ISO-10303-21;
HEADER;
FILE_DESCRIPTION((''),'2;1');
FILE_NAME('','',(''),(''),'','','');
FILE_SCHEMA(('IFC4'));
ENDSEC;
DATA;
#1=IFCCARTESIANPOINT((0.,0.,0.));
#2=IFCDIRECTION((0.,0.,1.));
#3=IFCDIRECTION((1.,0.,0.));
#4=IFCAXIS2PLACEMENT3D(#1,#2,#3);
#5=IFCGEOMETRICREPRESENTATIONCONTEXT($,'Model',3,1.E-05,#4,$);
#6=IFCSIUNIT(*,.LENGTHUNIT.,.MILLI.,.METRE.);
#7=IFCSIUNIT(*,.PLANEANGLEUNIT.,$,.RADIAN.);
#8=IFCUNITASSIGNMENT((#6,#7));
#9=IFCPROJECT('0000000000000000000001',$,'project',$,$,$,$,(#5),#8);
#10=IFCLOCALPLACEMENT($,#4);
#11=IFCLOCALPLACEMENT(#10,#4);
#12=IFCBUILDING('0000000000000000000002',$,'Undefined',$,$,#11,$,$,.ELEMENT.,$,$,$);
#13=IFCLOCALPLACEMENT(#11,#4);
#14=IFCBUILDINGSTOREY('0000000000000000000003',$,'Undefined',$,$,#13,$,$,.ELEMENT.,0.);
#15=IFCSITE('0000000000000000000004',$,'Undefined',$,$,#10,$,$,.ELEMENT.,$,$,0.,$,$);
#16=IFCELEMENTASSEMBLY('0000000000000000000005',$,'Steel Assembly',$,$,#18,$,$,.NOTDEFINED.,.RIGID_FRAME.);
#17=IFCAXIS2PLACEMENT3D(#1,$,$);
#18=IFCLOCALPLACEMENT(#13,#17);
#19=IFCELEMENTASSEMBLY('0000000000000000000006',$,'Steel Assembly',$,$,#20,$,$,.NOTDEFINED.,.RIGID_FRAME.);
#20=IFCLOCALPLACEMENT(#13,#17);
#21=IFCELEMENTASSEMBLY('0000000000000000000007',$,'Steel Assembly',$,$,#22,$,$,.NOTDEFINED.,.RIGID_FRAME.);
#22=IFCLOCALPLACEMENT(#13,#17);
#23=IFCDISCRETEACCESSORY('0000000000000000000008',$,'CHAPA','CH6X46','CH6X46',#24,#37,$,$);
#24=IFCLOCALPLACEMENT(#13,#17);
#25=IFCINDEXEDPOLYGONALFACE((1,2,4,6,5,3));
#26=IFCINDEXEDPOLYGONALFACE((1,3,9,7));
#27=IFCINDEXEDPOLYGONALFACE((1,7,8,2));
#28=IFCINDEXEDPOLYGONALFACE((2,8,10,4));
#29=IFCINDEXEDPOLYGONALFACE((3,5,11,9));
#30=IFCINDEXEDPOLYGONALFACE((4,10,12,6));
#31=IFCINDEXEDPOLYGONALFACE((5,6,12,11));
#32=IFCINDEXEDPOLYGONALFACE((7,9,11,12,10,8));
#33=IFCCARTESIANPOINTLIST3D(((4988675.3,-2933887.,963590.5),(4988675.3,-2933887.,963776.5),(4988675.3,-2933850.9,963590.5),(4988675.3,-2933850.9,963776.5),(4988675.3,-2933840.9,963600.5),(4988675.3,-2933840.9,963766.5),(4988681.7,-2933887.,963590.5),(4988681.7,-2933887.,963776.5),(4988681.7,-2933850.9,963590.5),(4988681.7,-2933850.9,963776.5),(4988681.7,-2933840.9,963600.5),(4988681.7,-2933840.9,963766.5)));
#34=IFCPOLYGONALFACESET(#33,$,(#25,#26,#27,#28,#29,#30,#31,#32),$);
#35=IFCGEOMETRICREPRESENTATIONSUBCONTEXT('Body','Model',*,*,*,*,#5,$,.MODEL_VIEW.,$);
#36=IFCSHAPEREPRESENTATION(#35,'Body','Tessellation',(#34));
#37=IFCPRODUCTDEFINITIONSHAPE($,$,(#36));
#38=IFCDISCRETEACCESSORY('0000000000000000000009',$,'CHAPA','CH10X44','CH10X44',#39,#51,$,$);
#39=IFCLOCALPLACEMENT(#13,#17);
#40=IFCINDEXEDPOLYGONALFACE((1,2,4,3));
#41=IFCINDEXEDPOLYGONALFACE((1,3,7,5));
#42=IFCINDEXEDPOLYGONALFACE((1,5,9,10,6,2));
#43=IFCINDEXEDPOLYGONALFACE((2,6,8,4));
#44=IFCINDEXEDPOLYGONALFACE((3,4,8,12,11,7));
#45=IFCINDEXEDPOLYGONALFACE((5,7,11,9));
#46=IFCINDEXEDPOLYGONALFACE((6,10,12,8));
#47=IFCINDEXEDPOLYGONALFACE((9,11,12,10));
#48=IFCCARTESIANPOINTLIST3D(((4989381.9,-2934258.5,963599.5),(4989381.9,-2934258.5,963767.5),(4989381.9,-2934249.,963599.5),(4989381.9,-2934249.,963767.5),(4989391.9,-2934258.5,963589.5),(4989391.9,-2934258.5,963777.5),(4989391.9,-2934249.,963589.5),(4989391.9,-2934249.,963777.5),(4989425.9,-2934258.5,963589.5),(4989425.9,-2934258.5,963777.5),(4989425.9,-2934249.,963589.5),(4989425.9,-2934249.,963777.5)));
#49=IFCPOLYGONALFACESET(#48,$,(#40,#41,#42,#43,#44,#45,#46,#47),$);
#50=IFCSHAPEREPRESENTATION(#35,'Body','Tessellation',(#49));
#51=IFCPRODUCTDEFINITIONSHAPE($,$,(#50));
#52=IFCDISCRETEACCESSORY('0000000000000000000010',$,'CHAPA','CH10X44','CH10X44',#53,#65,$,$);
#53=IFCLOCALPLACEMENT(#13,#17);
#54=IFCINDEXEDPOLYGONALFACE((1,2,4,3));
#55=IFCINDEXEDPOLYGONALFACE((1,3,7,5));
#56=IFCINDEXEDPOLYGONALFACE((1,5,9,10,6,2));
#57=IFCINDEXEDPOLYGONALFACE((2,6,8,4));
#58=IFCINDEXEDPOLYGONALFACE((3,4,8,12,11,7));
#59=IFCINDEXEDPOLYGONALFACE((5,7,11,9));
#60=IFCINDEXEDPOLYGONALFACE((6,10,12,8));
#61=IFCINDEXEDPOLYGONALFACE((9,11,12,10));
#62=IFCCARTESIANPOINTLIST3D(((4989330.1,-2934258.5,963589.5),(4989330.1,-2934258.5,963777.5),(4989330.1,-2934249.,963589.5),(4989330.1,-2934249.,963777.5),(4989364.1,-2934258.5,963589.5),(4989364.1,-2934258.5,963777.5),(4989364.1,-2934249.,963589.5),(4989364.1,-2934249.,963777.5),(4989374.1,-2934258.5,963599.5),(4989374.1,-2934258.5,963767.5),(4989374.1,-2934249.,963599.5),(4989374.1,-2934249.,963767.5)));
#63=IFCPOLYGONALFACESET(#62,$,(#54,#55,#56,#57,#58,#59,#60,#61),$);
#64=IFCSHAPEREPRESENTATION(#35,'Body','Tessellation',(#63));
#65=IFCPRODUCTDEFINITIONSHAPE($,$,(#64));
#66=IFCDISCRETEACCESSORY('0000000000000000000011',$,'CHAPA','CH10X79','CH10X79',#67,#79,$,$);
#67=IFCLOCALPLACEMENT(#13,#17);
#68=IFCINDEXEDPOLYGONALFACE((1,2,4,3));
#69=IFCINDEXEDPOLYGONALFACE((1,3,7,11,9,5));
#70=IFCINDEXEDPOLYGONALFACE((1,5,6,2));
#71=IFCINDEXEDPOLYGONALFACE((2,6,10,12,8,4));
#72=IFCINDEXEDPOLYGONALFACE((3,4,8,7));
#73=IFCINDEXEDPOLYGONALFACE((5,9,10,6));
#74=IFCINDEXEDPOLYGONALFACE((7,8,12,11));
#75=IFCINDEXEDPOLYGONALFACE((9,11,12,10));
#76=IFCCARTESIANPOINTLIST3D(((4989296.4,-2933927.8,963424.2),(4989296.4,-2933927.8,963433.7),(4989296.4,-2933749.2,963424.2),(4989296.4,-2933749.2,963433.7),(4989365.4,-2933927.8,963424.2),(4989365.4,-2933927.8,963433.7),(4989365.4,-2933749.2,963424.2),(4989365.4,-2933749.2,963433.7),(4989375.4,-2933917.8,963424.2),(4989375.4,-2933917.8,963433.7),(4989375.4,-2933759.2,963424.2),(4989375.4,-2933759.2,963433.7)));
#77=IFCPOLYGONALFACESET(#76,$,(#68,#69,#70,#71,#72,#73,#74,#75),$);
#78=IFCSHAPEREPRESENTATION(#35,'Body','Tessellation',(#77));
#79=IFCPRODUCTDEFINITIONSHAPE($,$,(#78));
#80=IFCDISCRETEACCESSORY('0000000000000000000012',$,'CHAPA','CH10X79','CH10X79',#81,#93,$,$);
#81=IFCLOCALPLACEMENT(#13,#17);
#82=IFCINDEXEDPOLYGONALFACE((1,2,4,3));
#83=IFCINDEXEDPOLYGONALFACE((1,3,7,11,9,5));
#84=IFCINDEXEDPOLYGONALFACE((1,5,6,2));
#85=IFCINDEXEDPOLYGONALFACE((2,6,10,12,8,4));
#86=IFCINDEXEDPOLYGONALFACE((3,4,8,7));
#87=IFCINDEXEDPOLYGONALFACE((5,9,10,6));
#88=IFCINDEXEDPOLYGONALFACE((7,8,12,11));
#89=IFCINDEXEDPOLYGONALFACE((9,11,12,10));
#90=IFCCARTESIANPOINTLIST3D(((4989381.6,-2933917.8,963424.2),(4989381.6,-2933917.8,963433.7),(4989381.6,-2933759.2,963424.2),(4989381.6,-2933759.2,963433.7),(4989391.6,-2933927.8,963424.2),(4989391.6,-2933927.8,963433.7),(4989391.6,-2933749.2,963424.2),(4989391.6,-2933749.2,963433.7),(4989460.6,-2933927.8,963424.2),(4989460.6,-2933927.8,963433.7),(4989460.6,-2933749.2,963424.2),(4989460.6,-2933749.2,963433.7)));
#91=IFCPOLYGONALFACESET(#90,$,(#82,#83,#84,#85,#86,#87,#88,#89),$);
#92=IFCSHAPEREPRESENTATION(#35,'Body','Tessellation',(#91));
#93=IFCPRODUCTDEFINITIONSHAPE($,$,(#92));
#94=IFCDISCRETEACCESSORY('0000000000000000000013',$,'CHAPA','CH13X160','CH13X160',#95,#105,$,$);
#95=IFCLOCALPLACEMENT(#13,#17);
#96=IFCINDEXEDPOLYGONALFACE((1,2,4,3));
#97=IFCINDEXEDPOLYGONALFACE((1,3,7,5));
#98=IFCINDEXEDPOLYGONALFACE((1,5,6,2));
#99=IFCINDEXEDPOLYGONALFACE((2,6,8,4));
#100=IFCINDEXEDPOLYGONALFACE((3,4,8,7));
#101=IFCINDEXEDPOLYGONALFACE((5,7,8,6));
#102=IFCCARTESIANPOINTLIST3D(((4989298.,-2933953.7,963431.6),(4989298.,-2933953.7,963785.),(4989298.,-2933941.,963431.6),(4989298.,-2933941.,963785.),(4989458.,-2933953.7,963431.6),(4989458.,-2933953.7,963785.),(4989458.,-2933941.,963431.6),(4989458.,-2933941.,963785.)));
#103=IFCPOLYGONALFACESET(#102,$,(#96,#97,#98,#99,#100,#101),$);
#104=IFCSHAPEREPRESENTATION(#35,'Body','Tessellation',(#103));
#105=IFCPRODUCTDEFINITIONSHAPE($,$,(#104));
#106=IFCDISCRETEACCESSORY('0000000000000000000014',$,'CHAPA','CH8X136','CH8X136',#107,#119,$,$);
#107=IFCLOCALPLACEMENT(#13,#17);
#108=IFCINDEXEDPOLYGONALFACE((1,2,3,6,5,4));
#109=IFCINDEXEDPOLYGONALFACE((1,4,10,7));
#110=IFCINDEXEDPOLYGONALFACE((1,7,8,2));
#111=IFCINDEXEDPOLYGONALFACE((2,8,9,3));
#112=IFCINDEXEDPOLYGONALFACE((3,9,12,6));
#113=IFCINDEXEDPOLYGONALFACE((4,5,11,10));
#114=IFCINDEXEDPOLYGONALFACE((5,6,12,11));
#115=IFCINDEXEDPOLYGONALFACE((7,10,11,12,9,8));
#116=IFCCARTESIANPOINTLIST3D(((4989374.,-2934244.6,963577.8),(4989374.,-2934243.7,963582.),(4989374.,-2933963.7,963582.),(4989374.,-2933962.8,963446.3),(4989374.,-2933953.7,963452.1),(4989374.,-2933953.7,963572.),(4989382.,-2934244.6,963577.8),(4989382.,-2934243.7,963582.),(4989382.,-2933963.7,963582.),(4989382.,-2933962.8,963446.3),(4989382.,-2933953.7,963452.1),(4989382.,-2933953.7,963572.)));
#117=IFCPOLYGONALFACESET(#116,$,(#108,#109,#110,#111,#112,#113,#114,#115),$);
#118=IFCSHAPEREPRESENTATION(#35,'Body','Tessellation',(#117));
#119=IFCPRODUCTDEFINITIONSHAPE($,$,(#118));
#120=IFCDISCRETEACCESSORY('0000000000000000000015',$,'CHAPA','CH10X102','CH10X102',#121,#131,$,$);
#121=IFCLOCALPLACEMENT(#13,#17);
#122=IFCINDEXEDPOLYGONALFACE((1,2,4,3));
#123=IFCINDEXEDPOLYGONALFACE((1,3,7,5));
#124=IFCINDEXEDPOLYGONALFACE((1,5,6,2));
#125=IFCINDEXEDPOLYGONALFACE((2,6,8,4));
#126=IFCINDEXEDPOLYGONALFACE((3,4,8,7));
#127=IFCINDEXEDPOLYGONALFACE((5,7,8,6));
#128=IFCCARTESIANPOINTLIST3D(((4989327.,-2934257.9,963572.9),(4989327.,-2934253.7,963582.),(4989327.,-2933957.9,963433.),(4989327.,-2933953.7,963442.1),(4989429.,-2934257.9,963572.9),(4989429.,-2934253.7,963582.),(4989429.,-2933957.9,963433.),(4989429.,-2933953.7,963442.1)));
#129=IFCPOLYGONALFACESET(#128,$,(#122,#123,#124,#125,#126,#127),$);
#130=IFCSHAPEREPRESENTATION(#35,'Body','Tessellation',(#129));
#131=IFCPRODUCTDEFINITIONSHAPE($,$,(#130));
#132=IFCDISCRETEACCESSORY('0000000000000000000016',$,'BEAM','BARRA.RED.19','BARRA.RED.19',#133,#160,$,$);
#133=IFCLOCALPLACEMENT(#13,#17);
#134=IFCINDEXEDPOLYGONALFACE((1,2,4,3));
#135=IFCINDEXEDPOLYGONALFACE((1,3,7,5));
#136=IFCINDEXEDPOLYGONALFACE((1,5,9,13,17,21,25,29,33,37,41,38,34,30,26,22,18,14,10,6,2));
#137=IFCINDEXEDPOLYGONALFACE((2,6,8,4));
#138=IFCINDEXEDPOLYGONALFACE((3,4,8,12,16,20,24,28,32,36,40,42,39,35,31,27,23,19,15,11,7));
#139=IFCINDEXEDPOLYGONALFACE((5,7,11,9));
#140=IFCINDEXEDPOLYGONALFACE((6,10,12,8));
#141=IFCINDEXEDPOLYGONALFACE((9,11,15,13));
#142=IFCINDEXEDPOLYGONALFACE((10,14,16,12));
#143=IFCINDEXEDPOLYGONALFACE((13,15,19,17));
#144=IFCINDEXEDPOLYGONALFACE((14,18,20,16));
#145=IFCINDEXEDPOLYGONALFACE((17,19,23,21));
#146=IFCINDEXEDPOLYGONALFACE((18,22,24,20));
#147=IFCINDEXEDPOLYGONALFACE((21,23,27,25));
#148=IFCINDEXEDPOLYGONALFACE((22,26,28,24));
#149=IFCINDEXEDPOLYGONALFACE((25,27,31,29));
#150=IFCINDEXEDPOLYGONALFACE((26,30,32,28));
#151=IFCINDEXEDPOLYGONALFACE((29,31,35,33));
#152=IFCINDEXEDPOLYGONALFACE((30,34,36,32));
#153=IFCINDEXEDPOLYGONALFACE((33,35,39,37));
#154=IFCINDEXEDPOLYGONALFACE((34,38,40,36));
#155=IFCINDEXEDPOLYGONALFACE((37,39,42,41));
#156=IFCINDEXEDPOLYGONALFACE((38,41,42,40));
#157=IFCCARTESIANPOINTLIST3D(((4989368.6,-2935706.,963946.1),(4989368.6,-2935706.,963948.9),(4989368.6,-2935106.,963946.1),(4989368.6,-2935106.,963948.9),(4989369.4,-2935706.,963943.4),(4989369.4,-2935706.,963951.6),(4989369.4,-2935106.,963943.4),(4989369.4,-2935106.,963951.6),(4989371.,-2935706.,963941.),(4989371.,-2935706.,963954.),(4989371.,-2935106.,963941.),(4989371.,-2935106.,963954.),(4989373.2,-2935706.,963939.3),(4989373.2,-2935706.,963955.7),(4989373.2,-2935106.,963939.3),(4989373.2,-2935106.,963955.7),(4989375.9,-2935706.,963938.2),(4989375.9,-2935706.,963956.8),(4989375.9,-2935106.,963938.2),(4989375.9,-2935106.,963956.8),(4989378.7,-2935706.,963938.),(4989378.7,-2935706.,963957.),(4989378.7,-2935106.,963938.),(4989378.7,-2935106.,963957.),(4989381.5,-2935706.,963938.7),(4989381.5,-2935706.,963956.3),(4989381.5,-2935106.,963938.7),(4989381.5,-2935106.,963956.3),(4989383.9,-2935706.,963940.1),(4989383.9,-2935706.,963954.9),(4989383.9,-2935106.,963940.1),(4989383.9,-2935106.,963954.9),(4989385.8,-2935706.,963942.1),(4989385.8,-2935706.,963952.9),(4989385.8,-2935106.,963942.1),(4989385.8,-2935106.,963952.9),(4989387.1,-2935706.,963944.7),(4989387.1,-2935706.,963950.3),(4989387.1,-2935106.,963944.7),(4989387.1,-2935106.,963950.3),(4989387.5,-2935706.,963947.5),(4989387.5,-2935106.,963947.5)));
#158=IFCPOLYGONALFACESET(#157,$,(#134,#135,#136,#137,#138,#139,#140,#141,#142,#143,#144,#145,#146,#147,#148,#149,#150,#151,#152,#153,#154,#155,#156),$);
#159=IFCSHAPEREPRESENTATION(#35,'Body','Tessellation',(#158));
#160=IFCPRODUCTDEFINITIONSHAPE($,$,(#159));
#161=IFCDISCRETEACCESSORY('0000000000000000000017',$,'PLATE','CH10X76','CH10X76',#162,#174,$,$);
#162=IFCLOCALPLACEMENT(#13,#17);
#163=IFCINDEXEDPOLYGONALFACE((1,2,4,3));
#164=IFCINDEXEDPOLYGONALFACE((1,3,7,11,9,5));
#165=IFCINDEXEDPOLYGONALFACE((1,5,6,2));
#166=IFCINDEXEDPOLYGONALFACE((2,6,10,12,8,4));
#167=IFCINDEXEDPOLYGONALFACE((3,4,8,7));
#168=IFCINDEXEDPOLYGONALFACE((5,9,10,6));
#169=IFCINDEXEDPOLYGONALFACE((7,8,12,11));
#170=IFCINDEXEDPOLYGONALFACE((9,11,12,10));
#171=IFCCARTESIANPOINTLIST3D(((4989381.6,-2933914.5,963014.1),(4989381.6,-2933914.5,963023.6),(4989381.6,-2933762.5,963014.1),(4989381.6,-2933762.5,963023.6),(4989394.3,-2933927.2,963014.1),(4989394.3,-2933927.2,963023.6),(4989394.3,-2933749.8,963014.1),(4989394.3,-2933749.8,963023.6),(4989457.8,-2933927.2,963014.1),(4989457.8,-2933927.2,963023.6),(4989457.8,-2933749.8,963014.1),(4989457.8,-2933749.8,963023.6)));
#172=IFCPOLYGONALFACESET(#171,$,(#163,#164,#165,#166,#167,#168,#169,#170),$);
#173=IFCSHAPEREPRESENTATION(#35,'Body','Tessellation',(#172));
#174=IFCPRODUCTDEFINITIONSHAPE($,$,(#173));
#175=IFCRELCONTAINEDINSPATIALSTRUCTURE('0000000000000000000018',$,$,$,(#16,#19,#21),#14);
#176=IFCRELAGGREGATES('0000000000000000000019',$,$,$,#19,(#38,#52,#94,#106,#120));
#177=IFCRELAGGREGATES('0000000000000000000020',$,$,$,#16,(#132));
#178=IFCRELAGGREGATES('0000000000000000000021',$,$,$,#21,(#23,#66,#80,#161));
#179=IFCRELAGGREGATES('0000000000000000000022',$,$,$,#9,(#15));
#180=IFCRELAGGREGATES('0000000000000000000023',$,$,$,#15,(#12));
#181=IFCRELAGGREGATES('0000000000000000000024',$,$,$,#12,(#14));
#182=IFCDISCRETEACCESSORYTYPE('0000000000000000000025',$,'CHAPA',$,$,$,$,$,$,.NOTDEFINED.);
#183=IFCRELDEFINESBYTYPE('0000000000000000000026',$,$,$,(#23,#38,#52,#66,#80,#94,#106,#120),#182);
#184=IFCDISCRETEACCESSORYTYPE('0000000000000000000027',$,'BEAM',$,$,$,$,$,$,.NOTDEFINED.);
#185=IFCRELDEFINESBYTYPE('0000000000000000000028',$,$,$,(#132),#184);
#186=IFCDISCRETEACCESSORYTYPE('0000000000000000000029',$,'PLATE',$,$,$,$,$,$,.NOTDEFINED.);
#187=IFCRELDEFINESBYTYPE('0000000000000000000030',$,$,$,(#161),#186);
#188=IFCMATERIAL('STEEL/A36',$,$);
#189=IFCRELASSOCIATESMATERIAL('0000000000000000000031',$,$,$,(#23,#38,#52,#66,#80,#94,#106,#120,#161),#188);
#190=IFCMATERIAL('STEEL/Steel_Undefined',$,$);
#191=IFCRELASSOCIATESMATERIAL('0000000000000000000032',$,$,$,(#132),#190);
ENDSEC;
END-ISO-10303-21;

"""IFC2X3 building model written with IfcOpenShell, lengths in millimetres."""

from ifc_helpers import new_model, si_unit, frame, origin_with_axes, origin_2d_with_axis, place, context, subcontext, project, spatial, polyline, rectangle, circle, outline, extrude, boolean, material, type_object, element, aggregate, save


model = new_model("IFC2X3")

# Units and contexts
model_context = context("Model", 3, precision=1e-05, world=origin_with_axes())
body_context = subcontext(model_context, "Body", "Model", "MODEL_VIEW")
ifc_project = project(units=[si_unit("LENGTHUNIT", "METRE", prefix="MILLI"), si_unit("PLANEANGLEUNIT", "RADIAN")], contexts=[model_context])

# Site, building, storey
site_placement = place(None, origin_with_axes())
site = spatial("IfcSite", under=ifc_project, at=site_placement, Name="Undefined", CompositionType="ELEMENT", RefElevation=0.0)
building_placement = place(site_placement, origin_with_axes())
building = spatial("IfcBuilding", under=site, at=building_placement, Name="Undefined", CompositionType="ELEMENT")
storey_placement = place(building_placement, origin_with_axes())
storey = spatial("IfcBuildingStorey", under=building, at=storey_placement, Name="Undefined", CompositionType="ELEMENT", Elevation=0.0)

# Element assembly
assembly_1_placement = place(storey_placement, origin_with_axes())
assembly_1 = element("IfcElementAssembly", 1, at=assembly_1_placement, inside=storey, Name="Steel Assembly", AssemblyPlace="NOTDEFINED", PredefinedType="RIGID_FRAME")
ifc_material_1 = material(Name="STEEL/Steel_Undefined")

# Element assembly
assembly_2_placement = place(storey_placement, origin_with_axes())
assembly_2 = element("IfcElementAssembly", 2, at=assembly_2_placement, inside=storey, Name="Steel Assembly", AssemblyPlace="NOTDEFINED", PredefinedType="RIGID_FRAME")
ifc_material_2 = material(Name="STEEL/A36")
discrete_accessory_type_1 = type_object("IfcDiscreteAccessoryType", Name="CHAPA")

# Element assembly, discrete accessory
assembly_3_placement = place(storey_placement, origin_with_axes())
assembly_3 = element("IfcElementAssembly", 3, at=assembly_3_placement, inside=storey, Name="Steel Assembly", AssemblyPlace="NOTDEFINED", PredefinedType="RIGID_FRAME")
discrete_accessory_1_placement = place(assembly_3_placement, frame((4988678.5, -2933840.9, 963776.5), z_axis=(1.0, 0.0, 0.0), x_axis=(0.0, -1.0, 0.0)))
discrete_accessory_1 = element("IfcDiscreteAccessory", 4, at=discrete_accessory_1_placement, type_object=discrete_accessory_type_1, material=ifc_material_2, Name="CHAPA", Description="CH6X46", ObjectType="CH6X46", context=body_context, shape_type="SweptSolid", body=[
    extrude(outline(polyline([(0.0, 10.0), (10.0, 0.0), (46.1, 0.0), (46.1, 186.0), (10.0, 186.0), (0.0, 176.0), (0.0, 10.0)])), frame((0.0, 0.0, -3.2), z_axis=(0.0, 0.0, 1.0), x_axis=(1.0, 0.0, 0.0)), (0.0, 0.0, 1.0), 6.4),
])

# Discrete accessories
discrete_accessory_2_placement = place(assembly_2_placement, frame((4989381.9, -2934253.7, 963589.5), z_axis=(0.0, -1.0, 0.0), x_axis=(1.0, 0.0, 0.0)))
discrete_accessory_2 = element("IfcDiscreteAccessory", 5, at=discrete_accessory_2_placement, type_object=discrete_accessory_type_1, material=ifc_material_2, Name="CHAPA", Description="CH10X44", ObjectType="CH10X44", context=body_context, shape_type="SweptSolid", body=[
    extrude(outline(polyline([(0.0, 10.0), (10.0, 0.0), (44.0, 0.0), (44.0, 188.0), (10.0, 188.0), (0.0, 178.0), (0.0, 10.0)])), frame((0.0, 0.0, -4.8), z_axis=(0.0, 0.0, 1.0), x_axis=(1.0, 0.0, 0.0)), (0.0, 0.0, 1.0), 9.5),
])
discrete_accessory_3_placement = place(assembly_2_placement, frame((4989374.1, -2934253.7, 963589.5), z_axis=(0.0, 1.0, 0.0), x_axis=(-1.0, 0.0, 0.0)))
discrete_accessory_3 = element("IfcDiscreteAccessory", 6, at=discrete_accessory_3_placement, type_object=discrete_accessory_type_1, material=ifc_material_2, Name="CHAPA", Description="CH10X44", ObjectType="CH10X44", context=body_context, shape_type="SweptSolid", body=[
    extrude(outline(polyline([(0.0, 10.0), (10.0, 0.0), (44.0, 0.0), (44.0, 188.0), (10.0, 188.0), (0.0, 178.0), (0.0, 10.0)])), frame((0.0, 0.0, -4.8), z_axis=(0.0, 0.0, 1.0), x_axis=(1.0, 0.0, 0.0)), (0.0, 0.0, 1.0), 9.5),
])
discrete_accessory_4_placement = place(assembly_3_placement, frame((4989296.4, -2933927.8, 963429.0), z_axis=(0.0, 0.0, 1.0), x_axis=(1.0, 0.0, 0.0)))
discrete_accessory_4 = element("IfcDiscreteAccessory", 7, at=discrete_accessory_4_placement, type_object=discrete_accessory_type_1, material=ifc_material_2, Name="CHAPA", Description="CH10X79", ObjectType="CH10X79", context=body_context, shape_type="SweptSolid", body=[
    extrude(outline(polyline([(0.0, 0.0), (69.0, 0.0), (79.0, 10.0), (79.0, 168.6), (69.0, 178.6), (0.0, 178.6), (0.0, 0.0)])), frame((0.0, 0.0, -4.8), z_axis=(0.0, 0.0, 1.0), x_axis=(1.0, 0.0, 0.0)), (0.0, 0.0, 1.0), 9.5),
])
discrete_accessory_5_placement = place(assembly_3_placement, frame((4989460.6, -2933927.8, 963429.0), z_axis=(0.0, 0.0, -1.0), x_axis=(-1.0, 0.0, 0.0)))
discrete_accessory_5 = element("IfcDiscreteAccessory", 8, at=discrete_accessory_5_placement, type_object=discrete_accessory_type_1, material=ifc_material_2, Name="CHAPA", Description="CH10X79", ObjectType="CH10X79", context=body_context, shape_type="SweptSolid", body=[
    extrude(outline(polyline([(0.0, 0.0), (69.0, 0.0), (79.0, 10.0), (79.0, 168.6), (69.0, 178.6), (0.0, 178.6), (0.0, 0.0)])), frame((0.0, 0.0, -4.8), z_axis=(0.0, 0.0, 1.0), x_axis=(1.0, 0.0, 0.0)), (0.0, 0.0, 1.0), 9.5),
])
discrete_accessory_6_placement = place(assembly_2_placement, frame((4989378.0, -2933947.4, 963431.6), z_axis=(0.0, -1.0, 0.0), x_axis=(0.0, 0.0, 1.0)))
discrete_accessory_6 = element("IfcDiscreteAccessory", 9, at=discrete_accessory_6_placement, type_object=discrete_accessory_type_1, material=ifc_material_2, Name="CHAPA", Description="CH13X160", ObjectType="CH13X160", context=body_context, shape_type="SweptSolid", body=[
    extrude(outline(polyline([(0.0, 80.0), (353.4, 80.0), (353.4, -80.0), (0.0, -80.0), (0.0, 80.0)])), frame((0.0, 0.0, -6.3), z_axis=(0.0, 0.0, 1.0), x_axis=(1.0, 0.0, 0.0)), (0.0, 0.0, 1.0), 12.7),
])
discrete_accessory_7_placement = place(assembly_2_placement, frame((4989378.0, -2933953.7, 963442.1), z_axis=(1.0, 0.0, 0.0), x_axis=(0.0, 0.0, 1.0)))
discrete_accessory_7 = element("IfcDiscreteAccessory", 10, at=discrete_accessory_7_placement, type_object=discrete_accessory_type_1, material=ifc_material_2, Name="CHAPA", Description="CH8X136", ObjectType="CH8X136", context=body_context, shape_type="SweptSolid", body=[
    extrude(outline(polyline([(4.2, 9.1), (10.0, 0.0), (129.9, 0.0), (139.9, 10.0), (139.9, 290.0), (135.7, 290.9), (4.2, 9.1)])), frame((0.0, 0.0, -4.0), z_axis=(0.0, 0.0, 1.0), x_axis=(1.0, 0.0, 0.0)), (0.0, 0.0, 1.0), 8.0),
])
discrete_accessory_8_placement = place(assembly_2_placement, frame((4989378.0, -2933955.8, 963437.6), z_axis=(-1.0, 0.0, 0.0), x_axis=(0.0, -0.906308, 0.422618)))
discrete_accessory_8 = element("IfcDiscreteAccessory", 11, at=discrete_accessory_8_placement, type_object=discrete_accessory_type_1, material=ifc_material_2, Name="CHAPA", Description="CH10X102", ObjectType="CH10X102", context=body_context, shape_type="SweptSolid", body=[
    extrude(rectangle(XDim=10.0, YDim=102.0, at=origin_2d_with_axis()), frame((331.0, 0.0, 0.0), z_axis=(-1.0, 0.0, 0.0), x_axis=(0.0, -1.0, 0.0)), (0.0, 0.0, 1.0), 331.0),
])
aggregate(assembly_2, [discrete_accessory_2, discrete_accessory_3, discrete_accessory_6, discrete_accessory_7, discrete_accessory_8])

# Discrete accessories
discrete_accessory_type_2 = type_object("IfcDiscreteAccessoryType", Name="BEAM")
discrete_accessory_9_placement = place(assembly_1_placement, frame((4989378.0, -2935106.0, 963947.5), z_axis=(0.0, 0.0, -1.0), x_axis=(0.0, -1.0, 0.0)))
discrete_accessory_9 = element("IfcDiscreteAccessory", 12, at=discrete_accessory_9_placement, type_object=discrete_accessory_type_2, material=ifc_material_1, Name="BEAM", Description="BARRA.RED.19", ObjectType="BARRA.RED.19", context=body_context, shape_type="SweptSolid", body=[
    extrude(circle(Radius=9.5, at=origin_2d_with_axis()), frame((600.0, 0.0, 0.0), z_axis=(-1.0, 0.0, 0.0), x_axis=(0.0, -1.0, 0.0)), (0.0, 0.0, 1.0), 600.0),
])
aggregate(assembly_1, [discrete_accessory_9])
discrete_accessory_type_3 = type_object("IfcDiscreteAccessoryType", Name="PLATE")
discrete_accessory_10_placement = place(assembly_3_placement, frame((4989381.6, -2933927.2, 963018.9), z_axis=(0.0, 0.0, 1.0), x_axis=(1.0, 0.0, 0.0)))
discrete_accessory_10 = element("IfcDiscreteAccessory", 13, at=discrete_accessory_10_placement, type_object=discrete_accessory_type_3, material=ifc_material_2, Name="PLATE", Description="CH10X76", ObjectType="CH10X76", context=body_context, shape_type="CSG", body=[
    boolean("DIFFERENCE", boolean("DIFFERENCE", extrude(outline(polyline([(0.0, 0.0), (76.2, 0.0), (76.2, 177.4), (0.0, 177.4), (0.0, 0.0)])), frame((0.0, 0.0, -4.8), z_axis=(0.0, 0.0, 1.0), x_axis=(1.0, 0.0, 0.0)), (0.0, 0.0, 1.0), 9.5), extrude(outline(polyline([(0.0, 0.0), (18.0, 0.0), (9.0, 9.0), (0.0, 0.0)])), frame((0.0, 164.7, -4.8), z_axis=(0.0, 0.0, 1.0), x_axis=(0.707107, 0.707107, 0.0)), (0.0, 0.0, 1.0), 15.0)), extrude(outline(polyline([(0.0, 0.0), (12.7, 0.0), (0.0, 12.7), (0.0, 0.0)])), frame((0.0, 0.0, -4.8), z_axis=(0.0, 0.0, 1.0), x_axis=(1.0, 0.0, 0.0)), (0.0, 0.0, 1.0), 15.0)),
])
aggregate(assembly_3, [discrete_accessory_1, discrete_accessory_4, discrete_accessory_5, discrete_accessory_10])

save(model, "model.ifc")
